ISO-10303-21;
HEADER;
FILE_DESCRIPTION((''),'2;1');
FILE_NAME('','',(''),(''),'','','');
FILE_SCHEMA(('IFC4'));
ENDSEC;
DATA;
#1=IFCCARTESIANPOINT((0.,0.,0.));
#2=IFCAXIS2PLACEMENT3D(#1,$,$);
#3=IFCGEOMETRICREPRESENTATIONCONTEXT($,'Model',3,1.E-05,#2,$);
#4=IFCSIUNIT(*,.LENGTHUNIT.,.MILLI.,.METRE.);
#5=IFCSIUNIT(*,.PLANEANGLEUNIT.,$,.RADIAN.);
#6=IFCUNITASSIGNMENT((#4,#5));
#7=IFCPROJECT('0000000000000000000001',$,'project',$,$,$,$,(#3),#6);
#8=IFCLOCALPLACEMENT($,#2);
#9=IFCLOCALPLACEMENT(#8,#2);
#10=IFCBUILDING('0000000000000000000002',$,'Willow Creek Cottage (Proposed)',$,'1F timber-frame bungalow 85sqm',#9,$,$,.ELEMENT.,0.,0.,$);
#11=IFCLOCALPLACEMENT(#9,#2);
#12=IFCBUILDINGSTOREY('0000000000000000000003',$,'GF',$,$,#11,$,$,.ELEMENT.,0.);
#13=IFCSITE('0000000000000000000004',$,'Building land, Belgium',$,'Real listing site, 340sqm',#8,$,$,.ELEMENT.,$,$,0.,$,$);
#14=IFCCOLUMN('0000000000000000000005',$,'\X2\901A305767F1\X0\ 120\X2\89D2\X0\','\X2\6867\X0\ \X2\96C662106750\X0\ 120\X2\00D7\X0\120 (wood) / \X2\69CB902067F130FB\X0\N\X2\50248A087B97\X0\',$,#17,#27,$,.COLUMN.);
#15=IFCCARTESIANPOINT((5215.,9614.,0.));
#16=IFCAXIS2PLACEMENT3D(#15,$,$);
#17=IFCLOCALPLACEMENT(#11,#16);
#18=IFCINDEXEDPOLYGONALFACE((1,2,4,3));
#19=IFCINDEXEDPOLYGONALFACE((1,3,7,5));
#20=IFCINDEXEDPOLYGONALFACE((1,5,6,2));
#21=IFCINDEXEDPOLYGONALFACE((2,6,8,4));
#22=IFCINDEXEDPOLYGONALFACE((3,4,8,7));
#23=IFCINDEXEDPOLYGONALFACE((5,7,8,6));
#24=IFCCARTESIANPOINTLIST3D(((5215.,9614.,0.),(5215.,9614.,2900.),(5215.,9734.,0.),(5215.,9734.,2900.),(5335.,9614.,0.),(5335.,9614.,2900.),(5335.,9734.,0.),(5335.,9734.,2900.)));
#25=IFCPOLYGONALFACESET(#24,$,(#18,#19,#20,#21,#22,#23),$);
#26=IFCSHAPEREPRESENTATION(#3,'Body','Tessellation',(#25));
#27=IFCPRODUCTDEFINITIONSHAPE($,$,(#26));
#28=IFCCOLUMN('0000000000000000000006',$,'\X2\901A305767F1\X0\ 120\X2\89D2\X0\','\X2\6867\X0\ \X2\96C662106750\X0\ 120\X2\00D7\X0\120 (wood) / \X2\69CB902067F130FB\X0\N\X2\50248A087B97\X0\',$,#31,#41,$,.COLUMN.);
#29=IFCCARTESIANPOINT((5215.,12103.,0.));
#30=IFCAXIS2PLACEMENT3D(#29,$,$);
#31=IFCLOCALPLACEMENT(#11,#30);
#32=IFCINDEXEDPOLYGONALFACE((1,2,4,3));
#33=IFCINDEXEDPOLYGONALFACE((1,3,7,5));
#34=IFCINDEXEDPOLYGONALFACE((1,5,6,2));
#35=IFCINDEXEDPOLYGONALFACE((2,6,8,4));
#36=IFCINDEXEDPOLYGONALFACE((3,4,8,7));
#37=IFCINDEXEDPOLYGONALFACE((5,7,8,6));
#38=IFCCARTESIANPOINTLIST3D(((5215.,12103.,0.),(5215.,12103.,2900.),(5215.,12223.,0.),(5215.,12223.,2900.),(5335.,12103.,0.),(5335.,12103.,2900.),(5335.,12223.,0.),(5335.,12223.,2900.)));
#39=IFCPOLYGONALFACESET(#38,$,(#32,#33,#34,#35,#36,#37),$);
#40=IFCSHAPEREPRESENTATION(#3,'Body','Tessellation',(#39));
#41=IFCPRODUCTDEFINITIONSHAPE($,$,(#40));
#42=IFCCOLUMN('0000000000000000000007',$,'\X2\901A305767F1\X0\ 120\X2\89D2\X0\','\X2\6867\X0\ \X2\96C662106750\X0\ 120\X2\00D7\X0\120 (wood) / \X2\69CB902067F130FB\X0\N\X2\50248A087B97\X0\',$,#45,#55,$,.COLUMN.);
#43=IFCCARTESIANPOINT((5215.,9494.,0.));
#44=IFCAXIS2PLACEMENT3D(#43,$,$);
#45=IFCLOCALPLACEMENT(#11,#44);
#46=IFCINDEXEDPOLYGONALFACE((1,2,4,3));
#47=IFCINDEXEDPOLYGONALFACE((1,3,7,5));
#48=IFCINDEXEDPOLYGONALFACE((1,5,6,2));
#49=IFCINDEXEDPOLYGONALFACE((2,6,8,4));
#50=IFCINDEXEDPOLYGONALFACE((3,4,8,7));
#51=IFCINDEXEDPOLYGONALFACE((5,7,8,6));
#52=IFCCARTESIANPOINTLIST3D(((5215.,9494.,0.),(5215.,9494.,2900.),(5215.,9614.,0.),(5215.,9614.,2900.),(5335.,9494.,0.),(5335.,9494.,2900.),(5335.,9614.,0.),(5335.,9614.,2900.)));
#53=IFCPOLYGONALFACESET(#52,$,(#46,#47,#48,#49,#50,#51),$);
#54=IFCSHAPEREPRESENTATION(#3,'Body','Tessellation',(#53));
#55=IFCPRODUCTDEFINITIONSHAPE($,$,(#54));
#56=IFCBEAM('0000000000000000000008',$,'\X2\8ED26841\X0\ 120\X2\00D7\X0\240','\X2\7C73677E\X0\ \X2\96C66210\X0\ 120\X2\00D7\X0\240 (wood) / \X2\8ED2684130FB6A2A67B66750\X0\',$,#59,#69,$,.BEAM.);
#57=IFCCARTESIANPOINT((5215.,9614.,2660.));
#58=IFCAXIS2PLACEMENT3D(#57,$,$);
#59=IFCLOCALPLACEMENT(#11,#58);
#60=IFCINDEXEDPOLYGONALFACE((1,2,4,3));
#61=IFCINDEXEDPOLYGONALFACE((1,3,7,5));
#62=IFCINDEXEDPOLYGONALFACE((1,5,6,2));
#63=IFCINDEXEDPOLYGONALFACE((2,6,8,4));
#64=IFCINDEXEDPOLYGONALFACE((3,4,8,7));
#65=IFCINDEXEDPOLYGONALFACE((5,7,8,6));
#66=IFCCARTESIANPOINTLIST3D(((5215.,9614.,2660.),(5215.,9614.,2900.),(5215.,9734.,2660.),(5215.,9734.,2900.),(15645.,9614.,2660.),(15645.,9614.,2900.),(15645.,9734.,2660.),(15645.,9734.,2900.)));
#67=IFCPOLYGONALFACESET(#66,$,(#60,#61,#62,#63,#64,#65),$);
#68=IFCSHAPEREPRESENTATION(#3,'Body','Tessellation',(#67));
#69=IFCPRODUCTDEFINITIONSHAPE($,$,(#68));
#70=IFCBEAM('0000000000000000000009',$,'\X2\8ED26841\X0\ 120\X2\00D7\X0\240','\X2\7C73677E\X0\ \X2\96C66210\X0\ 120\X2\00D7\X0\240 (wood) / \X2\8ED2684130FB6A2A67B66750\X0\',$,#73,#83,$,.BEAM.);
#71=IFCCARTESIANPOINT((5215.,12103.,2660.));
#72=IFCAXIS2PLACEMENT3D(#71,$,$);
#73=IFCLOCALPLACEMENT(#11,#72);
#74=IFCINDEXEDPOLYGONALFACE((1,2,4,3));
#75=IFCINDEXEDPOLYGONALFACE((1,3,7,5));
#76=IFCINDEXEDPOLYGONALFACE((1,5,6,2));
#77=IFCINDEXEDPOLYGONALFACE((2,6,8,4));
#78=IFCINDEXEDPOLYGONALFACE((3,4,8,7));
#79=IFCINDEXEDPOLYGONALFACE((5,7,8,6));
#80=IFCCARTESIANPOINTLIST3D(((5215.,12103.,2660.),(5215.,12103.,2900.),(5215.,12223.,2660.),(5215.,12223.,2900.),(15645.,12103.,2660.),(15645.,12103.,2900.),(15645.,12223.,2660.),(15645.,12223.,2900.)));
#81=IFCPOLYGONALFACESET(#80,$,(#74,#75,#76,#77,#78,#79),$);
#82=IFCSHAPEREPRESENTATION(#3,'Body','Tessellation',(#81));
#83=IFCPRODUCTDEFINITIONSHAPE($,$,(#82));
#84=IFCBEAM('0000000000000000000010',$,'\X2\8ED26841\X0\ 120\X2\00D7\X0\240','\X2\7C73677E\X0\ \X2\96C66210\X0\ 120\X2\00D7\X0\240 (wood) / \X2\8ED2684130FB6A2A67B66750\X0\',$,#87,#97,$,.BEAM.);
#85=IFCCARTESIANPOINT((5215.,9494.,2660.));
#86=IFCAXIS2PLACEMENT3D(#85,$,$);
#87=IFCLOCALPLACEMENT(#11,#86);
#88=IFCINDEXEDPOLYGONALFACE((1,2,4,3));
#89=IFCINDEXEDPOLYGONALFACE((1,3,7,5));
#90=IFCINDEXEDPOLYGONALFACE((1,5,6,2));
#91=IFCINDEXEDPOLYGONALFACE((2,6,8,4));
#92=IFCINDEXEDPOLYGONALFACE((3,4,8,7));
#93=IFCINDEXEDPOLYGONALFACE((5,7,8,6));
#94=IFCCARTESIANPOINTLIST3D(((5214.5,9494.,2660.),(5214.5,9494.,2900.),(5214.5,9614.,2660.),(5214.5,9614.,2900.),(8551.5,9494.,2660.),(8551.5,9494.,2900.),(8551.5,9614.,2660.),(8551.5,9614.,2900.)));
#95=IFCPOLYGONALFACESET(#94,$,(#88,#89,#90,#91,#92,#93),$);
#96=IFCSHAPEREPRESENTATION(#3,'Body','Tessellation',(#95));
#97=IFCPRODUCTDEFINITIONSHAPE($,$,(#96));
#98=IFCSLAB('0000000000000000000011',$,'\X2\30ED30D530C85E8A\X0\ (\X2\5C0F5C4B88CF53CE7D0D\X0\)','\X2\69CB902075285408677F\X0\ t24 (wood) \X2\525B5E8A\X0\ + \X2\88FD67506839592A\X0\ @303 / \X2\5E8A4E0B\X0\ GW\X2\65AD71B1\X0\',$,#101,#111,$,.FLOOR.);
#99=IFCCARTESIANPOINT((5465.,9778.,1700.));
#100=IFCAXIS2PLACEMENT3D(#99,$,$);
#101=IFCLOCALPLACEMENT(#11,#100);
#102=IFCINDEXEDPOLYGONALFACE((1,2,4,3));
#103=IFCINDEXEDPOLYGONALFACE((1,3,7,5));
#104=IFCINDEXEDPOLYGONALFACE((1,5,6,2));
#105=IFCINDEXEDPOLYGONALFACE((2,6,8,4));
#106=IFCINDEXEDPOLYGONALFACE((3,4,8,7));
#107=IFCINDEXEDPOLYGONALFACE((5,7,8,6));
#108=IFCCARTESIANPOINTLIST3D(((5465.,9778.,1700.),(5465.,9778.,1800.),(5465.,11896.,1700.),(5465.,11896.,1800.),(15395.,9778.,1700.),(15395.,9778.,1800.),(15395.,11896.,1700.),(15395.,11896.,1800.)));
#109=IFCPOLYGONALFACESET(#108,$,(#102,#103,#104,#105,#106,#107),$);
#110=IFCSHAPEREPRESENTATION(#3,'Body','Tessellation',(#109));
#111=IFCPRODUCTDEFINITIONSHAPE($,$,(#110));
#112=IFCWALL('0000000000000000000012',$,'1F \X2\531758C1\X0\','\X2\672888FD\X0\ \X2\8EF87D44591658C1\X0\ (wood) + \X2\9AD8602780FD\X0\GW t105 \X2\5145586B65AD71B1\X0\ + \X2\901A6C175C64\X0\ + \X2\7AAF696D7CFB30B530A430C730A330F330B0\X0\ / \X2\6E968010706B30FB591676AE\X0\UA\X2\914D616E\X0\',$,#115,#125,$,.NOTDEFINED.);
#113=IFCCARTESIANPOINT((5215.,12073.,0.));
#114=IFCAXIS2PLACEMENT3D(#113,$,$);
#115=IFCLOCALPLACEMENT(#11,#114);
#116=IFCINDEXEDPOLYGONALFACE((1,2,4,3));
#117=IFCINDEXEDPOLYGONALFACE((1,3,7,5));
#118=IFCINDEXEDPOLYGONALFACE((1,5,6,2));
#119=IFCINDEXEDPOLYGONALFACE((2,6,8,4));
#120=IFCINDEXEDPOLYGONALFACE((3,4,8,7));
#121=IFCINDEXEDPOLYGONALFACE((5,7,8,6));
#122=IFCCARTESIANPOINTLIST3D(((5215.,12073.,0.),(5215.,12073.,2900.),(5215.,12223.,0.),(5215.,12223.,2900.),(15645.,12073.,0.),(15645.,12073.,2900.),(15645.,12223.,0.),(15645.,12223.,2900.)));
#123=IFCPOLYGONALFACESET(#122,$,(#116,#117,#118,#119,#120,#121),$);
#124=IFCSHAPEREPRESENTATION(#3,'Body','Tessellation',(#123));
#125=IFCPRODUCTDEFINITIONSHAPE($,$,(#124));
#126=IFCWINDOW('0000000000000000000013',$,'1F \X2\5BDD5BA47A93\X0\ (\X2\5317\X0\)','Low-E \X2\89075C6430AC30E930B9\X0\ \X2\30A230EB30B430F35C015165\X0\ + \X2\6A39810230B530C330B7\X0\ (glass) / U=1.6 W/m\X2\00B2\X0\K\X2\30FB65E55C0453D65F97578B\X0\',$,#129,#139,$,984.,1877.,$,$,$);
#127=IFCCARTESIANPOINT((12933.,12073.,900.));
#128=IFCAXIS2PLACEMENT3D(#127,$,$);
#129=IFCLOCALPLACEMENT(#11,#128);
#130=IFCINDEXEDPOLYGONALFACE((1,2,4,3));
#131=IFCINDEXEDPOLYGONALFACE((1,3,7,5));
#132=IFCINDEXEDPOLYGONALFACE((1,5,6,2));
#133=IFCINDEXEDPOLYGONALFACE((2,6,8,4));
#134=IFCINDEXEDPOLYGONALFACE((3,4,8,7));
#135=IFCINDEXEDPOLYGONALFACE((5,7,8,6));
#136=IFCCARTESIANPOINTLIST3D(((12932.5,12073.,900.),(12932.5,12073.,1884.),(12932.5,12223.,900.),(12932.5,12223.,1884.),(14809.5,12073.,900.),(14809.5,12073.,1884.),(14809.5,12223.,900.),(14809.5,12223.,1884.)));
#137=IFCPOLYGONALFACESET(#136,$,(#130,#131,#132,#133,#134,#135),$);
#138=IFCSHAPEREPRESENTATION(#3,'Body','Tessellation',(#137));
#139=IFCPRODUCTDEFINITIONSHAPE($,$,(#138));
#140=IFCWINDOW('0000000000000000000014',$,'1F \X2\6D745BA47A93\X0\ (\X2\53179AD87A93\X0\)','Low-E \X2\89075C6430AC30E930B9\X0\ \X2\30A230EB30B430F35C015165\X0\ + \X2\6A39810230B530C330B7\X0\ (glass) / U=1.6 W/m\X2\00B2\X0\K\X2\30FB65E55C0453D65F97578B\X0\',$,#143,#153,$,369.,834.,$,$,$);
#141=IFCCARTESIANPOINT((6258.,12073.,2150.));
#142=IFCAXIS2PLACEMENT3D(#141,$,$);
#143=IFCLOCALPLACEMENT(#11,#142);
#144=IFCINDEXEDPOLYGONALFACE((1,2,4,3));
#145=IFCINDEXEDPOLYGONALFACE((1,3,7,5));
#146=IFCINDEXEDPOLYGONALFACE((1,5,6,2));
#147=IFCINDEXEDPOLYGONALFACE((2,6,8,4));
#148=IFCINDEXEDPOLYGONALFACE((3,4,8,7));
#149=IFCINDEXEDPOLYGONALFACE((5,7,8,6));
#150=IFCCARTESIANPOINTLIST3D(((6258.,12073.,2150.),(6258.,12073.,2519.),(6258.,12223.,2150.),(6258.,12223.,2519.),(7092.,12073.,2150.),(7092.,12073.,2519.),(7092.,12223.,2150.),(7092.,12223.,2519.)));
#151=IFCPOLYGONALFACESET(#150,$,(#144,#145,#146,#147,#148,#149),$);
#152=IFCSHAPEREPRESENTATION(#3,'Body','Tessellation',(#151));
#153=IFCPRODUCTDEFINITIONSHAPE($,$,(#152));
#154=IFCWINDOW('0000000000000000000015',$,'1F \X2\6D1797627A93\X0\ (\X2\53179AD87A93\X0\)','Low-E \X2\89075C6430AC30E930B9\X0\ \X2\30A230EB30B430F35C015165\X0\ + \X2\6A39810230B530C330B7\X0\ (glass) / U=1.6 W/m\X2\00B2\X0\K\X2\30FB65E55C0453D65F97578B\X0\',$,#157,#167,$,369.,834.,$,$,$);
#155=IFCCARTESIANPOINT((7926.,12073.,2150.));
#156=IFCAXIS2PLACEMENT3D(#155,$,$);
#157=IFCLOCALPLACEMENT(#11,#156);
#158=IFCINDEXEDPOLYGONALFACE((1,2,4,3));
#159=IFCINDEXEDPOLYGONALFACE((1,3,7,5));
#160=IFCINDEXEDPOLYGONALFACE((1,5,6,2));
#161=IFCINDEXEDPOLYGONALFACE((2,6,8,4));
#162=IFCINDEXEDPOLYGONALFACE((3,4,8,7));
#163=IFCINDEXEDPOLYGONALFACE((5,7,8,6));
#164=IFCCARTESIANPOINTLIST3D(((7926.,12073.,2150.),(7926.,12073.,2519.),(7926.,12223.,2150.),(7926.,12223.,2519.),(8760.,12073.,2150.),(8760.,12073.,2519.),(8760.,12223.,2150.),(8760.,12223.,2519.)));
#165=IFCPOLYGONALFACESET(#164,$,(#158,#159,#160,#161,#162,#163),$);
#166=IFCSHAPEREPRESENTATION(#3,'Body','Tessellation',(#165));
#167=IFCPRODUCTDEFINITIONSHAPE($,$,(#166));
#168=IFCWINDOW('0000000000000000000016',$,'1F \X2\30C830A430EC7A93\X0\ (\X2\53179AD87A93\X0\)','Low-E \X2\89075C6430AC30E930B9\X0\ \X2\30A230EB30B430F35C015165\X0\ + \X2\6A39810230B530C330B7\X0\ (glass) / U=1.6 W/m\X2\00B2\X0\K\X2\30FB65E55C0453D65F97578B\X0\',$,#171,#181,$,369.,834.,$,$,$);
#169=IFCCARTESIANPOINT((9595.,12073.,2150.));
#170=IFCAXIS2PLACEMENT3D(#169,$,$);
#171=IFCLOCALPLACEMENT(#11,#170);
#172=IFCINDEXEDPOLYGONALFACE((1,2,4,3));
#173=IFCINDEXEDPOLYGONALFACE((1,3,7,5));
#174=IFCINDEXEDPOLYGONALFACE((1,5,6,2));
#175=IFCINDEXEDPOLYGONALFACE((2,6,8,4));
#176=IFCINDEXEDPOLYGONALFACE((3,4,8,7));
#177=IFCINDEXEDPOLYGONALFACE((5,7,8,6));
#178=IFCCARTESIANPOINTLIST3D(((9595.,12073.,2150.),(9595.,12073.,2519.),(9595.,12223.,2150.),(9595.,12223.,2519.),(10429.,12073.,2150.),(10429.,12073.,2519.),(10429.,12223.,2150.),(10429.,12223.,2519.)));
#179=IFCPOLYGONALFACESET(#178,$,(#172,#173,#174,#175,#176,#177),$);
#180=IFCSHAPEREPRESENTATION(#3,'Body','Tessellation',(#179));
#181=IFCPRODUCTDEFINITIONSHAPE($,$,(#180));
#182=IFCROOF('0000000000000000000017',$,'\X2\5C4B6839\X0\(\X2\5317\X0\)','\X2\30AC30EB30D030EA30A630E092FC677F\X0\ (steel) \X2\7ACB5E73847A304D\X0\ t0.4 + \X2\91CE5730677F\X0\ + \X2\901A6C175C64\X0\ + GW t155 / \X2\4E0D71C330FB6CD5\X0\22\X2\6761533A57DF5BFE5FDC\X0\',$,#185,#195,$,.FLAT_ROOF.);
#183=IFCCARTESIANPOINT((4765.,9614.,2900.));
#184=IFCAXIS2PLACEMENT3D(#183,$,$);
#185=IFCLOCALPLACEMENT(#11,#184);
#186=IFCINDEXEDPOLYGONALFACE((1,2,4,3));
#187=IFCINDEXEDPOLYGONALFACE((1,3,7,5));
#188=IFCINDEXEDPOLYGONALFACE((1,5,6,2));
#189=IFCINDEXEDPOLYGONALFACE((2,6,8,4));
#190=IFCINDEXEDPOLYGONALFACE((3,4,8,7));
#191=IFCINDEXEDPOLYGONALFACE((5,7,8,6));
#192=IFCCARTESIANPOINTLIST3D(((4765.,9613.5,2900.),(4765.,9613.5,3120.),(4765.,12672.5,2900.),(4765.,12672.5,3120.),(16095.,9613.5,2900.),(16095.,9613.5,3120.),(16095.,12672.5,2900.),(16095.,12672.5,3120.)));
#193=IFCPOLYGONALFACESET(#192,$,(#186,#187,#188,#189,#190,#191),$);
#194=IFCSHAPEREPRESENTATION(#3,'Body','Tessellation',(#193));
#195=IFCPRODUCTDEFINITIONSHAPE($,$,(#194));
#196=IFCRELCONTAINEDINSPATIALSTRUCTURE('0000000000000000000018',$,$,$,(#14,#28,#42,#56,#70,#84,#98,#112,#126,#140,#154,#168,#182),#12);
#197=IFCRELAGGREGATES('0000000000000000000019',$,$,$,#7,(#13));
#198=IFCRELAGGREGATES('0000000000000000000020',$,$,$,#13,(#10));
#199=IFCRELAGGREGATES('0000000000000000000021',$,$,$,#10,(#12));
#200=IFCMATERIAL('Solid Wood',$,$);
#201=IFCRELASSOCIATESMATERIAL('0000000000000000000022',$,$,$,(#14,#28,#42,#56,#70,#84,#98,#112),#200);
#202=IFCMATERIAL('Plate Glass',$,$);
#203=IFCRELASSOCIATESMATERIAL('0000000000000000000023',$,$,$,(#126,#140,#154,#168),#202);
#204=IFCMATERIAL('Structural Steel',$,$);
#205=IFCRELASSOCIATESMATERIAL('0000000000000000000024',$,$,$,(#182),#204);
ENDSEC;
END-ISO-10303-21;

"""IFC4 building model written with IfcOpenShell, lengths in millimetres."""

from ifc_helpers import new_model, si_unit, frame, frame_2d, origin, place, context, project, spatial, rectangle, extrude, material, element, fill, save


model = new_model("IFC4")

# Units and contexts
model_context = context("Model", 3, precision=1e-05, world=origin())
ifc_project = project(units=[si_unit("LENGTHUNIT", "METRE", prefix="MILLI"), si_unit("PLANEANGLEUNIT", "RADIAN")], contexts=[model_context])

# Site, building, storey
site_placement = place(None, origin())
site = spatial("IfcSite", under=ifc_project, at=site_placement, Name="Building land, Belgium", ObjectType="Real listing site, 340sqm", CompositionType="ELEMENT", RefElevation=0.0)
building_placement = place(site_placement, origin())
building = spatial("IfcBuilding", under=site, at=building_placement, Name="Willow Creek Cottage (Proposed)", ObjectType="1F timber-frame bungalow 85sqm", CompositionType="ELEMENT", ElevationOfRefHeight=0.0, ElevationOfTerrain=0.0)
storey_placement = place(building_placement, origin())
storey = spatial("IfcBuildingStorey", under=building, at=storey_placement, Name="GF", CompositionType="ELEMENT", Elevation=0.0)

# Columns
ifc_material_1 = material(Name="Solid Wood")
column_1_placement = place(storey_placement, frame((5215.0, 9614.0, 0.0)))
element("IfcColumn", 1, at=column_1_placement, inside=storey, material=ifc_material_1, Name="通し柱 120角", Description="桧 集成材 120×120 (wood) / 構造柱・N値計算", PredefinedType="COLUMN", context=model_context, shape_type="SweptSolid", body=[
    extrude(rectangle(XDim=120.0, YDim=120.0, at=frame_2d((60.0, 60.0))), frame((5215.0, 9614.0, 0.0)), (0.0, 0.0, 1.0), 2900.0),
])
column_2_placement = place(storey_placement, frame((5215.0, 12103.0, 0.0)))
element("IfcColumn", 2, at=column_2_placement, inside=storey, material=ifc_material_1, Name="通し柱 120角", Description="桧 集成材 120×120 (wood) / 構造柱・N値計算", PredefinedType="COLUMN", context=model_context, shape_type="SweptSolid", body=[
    extrude(rectangle(XDim=120.0, YDim=120.0, at=frame_2d((60.0, 60.0))), frame((5215.0, 12103.0, 0.0)), (0.0, 0.0, 1.0), 2900.0),
])
column_3_placement = place(storey_placement, frame((5215.0, 9494.0, 0.0)))
element("IfcColumn", 3, at=column_3_placement, inside=storey, material=ifc_material_1, Name="通し柱 120角", Description="桧 集成材 120×120 (wood) / 構造柱・N値計算", PredefinedType="COLUMN", context=model_context, shape_type="SweptSolid", body=[
    extrude(rectangle(XDim=120.0, YDim=120.0, at=frame_2d((60.0, 60.0))), frame((5215.0, 9494.0, 0.0)), (0.0, 0.0, 1.0), 2900.0),
])

# Beams
beam_1_placement = place(storey_placement, frame((5215.0, 9614.0, 2660.0)))
element("IfcBeam", 4, at=beam_1_placement, inside=storey, material=ifc_material_1, Name="軒桁 120×240", Description="米松 集成 120×240 (wood) / 軒桁・横架材", PredefinedType="BEAM", context=model_context, shape_type="SweptSolid", body=[
    extrude(rectangle(XDim=10430.0, YDim=120.0, at=frame_2d((5215.0, 60.0))), frame((5215.0, 9614.0, 2660.0)), (0.0, 0.0, 1.0), 240.0),
])
beam_2_placement = place(storey_placement, frame((5215.0, 12103.0, 2660.0)))
element("IfcBeam", 5, at=beam_2_placement, inside=storey, material=ifc_material_1, Name="軒桁 120×240", Description="米松 集成 120×240 (wood) / 軒桁・横架材", PredefinedType="BEAM", context=model_context, shape_type="SweptSolid", body=[
    extrude(rectangle(XDim=10430.0, YDim=120.0, at=frame_2d((5215.0, 60.0))), frame((5215.0, 12103.0, 2660.0)), (0.0, 0.0, 1.0), 240.0),
])
beam_3_placement = place(storey_placement, frame((5215.0, 9494.0, 2660.0)))
element("IfcBeam", 6, at=beam_3_placement, inside=storey, material=ifc_material_1, Name="軒桁 120×240", Description="米松 集成 120×240 (wood) / 軒桁・横架材", PredefinedType="BEAM", context=model_context, shape_type="SweptSolid", body=[
    extrude(rectangle(XDim=3337.0, YDim=120.0, at=frame_2d((1668.0, 60.0))), frame((5215.0, 9494.0, 2660.0)), (0.0, 0.0, 1.0), 240.0),
])

# Slab
slab_1_placement = place(storey_placement, frame((5465.0, 9778.0, 1700.0)))
element("IfcSlab", 7, at=slab_1_placement, inside=storey, material=ifc_material_1, Name="ロフト床 (小屋裏収納)", Description="構造用合板 t24 (wood) 剛床 + 製材根太 @303 / 床下 GW断熱", PredefinedType="FLOOR", context=model_context, shape_type="SweptSolid", body=[
    extrude(rectangle(XDim=9930.0, YDim=2118.0, at=frame_2d((4965.0, 1059.0))), frame((5465.0, 9778.0, 1700.0)), (0.0, 0.0, 1.0), 100.0),
])

# Wall, openings, windows
wall_1_placement = place(storey_placement, frame((5215.0, 12073.0, 0.0)))
wall_1 = element("IfcWall", 8, at=wall_1_placement, inside=storey, material=ifc_material_1, Name="1F 北壁", Description="木製 軸組外壁 (wood) + 高性能GW t105 充填断熱 + 通気層 + 窯業系サイディング / 準耐火・外皮UA配慮", PredefinedType="NOTDEFINED", context=model_context, shape_type="SweptSolid", body=[
    extrude(rectangle(XDim=10430.0, YDim=150.0, at=frame_2d((5215.0, 75.0))), frame((5215.0, 12073.0, 0.0)), (0.0, 0.0, 1.0), 2900.0),
])
opening_1_placement = place(storey_placement, frame((12933.0, 12073.0, 900.0)))
opening_1 = element("IfcOpeningElement", 9, at=opening_1_placement, cuts=wall_1, PredefinedType="NOTDEFINED", context=model_context, shape_type="SweptSolid", body=[
    extrude(rectangle(XDim=1877.0, YDim=150.0, at=frame_2d((938.0, 75.0))), frame((12933.0, 12073.0, 900.0)), (0.0, 0.0, 1.0), 984.0),
])
opening_2_placement = place(storey_placement, frame((6258.0, 12073.0, 2150.0)))
opening_2 = element("IfcOpeningElement", 10, at=opening_2_placement, cuts=wall_1, PredefinedType="NOTDEFINED", context=model_context, shape_type="SweptSolid", body=[
    extrude(rectangle(XDim=834.0, YDim=150.0, at=frame_2d((417.0, 75.0))), frame((6258.0, 12073.0, 2150.0)), (0.0, 0.0, 1.0), 369.0),
])
opening_3_placement = place(storey_placement, frame((7926.0, 12073.0, 2150.0)))
opening_3 = element("IfcOpeningElement", 11, at=opening_3_placement, cuts=wall_1, PredefinedType="NOTDEFINED", context=model_context, shape_type="SweptSolid", body=[
    extrude(rectangle(XDim=834.0, YDim=150.0, at=frame_2d((417.0, 75.0))), frame((7926.0, 12073.0, 2150.0)), (0.0, 0.0, 1.0), 369.0),
])
opening_4_placement = place(storey_placement, frame((9595.0, 12073.0, 2150.0)))
opening_4 = element("IfcOpeningElement", 12, at=opening_4_placement, cuts=wall_1, PredefinedType="NOTDEFINED", context=model_context, shape_type="SweptSolid", body=[
    extrude(rectangle(XDim=834.0, YDim=150.0, at=frame_2d((417.0, 75.0))), frame((9595.0, 12073.0, 2150.0)), (0.0, 0.0, 1.0), 369.0),
])
ifc_material_2 = material(Name="Plate Glass")
window_1_placement = place(storey_placement, frame((12933.0, 12073.0, 900.0)))
window_1 = element("IfcWindow", 13, at=window_1_placement, inside=storey, material=ifc_material_2, Name="1F 寝室窓 (北)", Description="Low-E 複層ガラス アルゴン封入 + 樹脂サッシ (glass) / U=1.6 W/m²K・日射取得型", OverallHeight=984.0, OverallWidth=1877.0, context=model_context, shape_type="SweptSolid", body=[
    extrude(rectangle(XDim=1877.0, YDim=150.0, at=frame_2d((938.0, 75.0))), frame((12933.0, 12073.0, 900.0)), (0.0, 0.0, 1.0), 984.0),
])
fill(opening_1, window_1)
window_2_placement = place(storey_placement, frame((6258.0, 12073.0, 2150.0)))
window_2 = element("IfcWindow", 14, at=window_2_placement, inside=storey, material=ifc_material_2, Name="1F 浴室窓 (北高窓)", Description="Low-E 複層ガラス アルゴン封入 + 樹脂サッシ (glass) / U=1.6 W/m²K・日射取得型", OverallHeight=369.0, OverallWidth=834.0, context=model_context, shape_type="SweptSolid", body=[
    extrude(rectangle(XDim=834.0, YDim=150.0, at=frame_2d((417.0, 75.0))), frame((6258.0, 12073.0, 2150.0)), (0.0, 0.0, 1.0), 369.0),
])
fill(opening_2, window_2)
window_3_placement = place(storey_placement, frame((7926.0, 12073.0, 2150.0)))
window_3 = element("IfcWindow", 15, at=window_3_placement, inside=storey, material=ifc_material_2, Name="1F 洗面窓 (北高窓)", Description="Low-E 複層ガラス アルゴン封入 + 樹脂サッシ (glass) / U=1.6 W/m²K・日射取得型", OverallHeight=369.0, OverallWidth=834.0, context=model_context, shape_type="SweptSolid", body=[
    extrude(rectangle(XDim=834.0, YDim=150.0, at=frame_2d((417.0, 75.0))), frame((7926.0, 12073.0, 2150.0)), (0.0, 0.0, 1.0), 369.0),
])
fill(opening_3, window_3)
window_4_placement = place(storey_placement, frame((9595.0, 12073.0, 2150.0)))
window_4 = element("IfcWindow", 16, at=window_4_placement, inside=storey, material=ifc_material_2, Name="1F トイレ窓 (北高窓)", Description="Low-E 複層ガラス アルゴン封入 + 樹脂サッシ (glass) / U=1.6 W/m²K・日射取得型", OverallHeight=369.0, OverallWidth=834.0, context=model_context, shape_type="SweptSolid", body=[
    extrude(rectangle(XDim=834.0, YDim=150.0, at=frame_2d((417.0, 75.0))), frame((9595.0, 12073.0, 2150.0)), (0.0, 0.0, 1.0), 369.0),
])
fill(opening_4, window_4)

# Roof
ifc_material_3 = material(Name="Structural Steel")
roof_placement = place(storey_placement, frame((4765.0, 9614.0, 2900.0)))
element("IfcRoof", 17, at=roof_placement, inside=storey, material=ifc_material_3, Name="屋根(北)", Description="ガルバリウム鋼板 (steel) 立平葺き t0.4 + 野地板 + 通気層 + GW t155 / 不燃・法22条区域対応", PredefinedType="FLAT_ROOF", context=model_context, shape_type="SweptSolid", body=[
    extrude(rectangle(XDim=11330.0, YDim=3059.0, at=frame_2d((5665.0, 1529.0))), frame((4765.0, 9614.0, 2900.0)), (0.0, 0.0, 1.0), 220.0),
])

save(model, "model.ifc")
